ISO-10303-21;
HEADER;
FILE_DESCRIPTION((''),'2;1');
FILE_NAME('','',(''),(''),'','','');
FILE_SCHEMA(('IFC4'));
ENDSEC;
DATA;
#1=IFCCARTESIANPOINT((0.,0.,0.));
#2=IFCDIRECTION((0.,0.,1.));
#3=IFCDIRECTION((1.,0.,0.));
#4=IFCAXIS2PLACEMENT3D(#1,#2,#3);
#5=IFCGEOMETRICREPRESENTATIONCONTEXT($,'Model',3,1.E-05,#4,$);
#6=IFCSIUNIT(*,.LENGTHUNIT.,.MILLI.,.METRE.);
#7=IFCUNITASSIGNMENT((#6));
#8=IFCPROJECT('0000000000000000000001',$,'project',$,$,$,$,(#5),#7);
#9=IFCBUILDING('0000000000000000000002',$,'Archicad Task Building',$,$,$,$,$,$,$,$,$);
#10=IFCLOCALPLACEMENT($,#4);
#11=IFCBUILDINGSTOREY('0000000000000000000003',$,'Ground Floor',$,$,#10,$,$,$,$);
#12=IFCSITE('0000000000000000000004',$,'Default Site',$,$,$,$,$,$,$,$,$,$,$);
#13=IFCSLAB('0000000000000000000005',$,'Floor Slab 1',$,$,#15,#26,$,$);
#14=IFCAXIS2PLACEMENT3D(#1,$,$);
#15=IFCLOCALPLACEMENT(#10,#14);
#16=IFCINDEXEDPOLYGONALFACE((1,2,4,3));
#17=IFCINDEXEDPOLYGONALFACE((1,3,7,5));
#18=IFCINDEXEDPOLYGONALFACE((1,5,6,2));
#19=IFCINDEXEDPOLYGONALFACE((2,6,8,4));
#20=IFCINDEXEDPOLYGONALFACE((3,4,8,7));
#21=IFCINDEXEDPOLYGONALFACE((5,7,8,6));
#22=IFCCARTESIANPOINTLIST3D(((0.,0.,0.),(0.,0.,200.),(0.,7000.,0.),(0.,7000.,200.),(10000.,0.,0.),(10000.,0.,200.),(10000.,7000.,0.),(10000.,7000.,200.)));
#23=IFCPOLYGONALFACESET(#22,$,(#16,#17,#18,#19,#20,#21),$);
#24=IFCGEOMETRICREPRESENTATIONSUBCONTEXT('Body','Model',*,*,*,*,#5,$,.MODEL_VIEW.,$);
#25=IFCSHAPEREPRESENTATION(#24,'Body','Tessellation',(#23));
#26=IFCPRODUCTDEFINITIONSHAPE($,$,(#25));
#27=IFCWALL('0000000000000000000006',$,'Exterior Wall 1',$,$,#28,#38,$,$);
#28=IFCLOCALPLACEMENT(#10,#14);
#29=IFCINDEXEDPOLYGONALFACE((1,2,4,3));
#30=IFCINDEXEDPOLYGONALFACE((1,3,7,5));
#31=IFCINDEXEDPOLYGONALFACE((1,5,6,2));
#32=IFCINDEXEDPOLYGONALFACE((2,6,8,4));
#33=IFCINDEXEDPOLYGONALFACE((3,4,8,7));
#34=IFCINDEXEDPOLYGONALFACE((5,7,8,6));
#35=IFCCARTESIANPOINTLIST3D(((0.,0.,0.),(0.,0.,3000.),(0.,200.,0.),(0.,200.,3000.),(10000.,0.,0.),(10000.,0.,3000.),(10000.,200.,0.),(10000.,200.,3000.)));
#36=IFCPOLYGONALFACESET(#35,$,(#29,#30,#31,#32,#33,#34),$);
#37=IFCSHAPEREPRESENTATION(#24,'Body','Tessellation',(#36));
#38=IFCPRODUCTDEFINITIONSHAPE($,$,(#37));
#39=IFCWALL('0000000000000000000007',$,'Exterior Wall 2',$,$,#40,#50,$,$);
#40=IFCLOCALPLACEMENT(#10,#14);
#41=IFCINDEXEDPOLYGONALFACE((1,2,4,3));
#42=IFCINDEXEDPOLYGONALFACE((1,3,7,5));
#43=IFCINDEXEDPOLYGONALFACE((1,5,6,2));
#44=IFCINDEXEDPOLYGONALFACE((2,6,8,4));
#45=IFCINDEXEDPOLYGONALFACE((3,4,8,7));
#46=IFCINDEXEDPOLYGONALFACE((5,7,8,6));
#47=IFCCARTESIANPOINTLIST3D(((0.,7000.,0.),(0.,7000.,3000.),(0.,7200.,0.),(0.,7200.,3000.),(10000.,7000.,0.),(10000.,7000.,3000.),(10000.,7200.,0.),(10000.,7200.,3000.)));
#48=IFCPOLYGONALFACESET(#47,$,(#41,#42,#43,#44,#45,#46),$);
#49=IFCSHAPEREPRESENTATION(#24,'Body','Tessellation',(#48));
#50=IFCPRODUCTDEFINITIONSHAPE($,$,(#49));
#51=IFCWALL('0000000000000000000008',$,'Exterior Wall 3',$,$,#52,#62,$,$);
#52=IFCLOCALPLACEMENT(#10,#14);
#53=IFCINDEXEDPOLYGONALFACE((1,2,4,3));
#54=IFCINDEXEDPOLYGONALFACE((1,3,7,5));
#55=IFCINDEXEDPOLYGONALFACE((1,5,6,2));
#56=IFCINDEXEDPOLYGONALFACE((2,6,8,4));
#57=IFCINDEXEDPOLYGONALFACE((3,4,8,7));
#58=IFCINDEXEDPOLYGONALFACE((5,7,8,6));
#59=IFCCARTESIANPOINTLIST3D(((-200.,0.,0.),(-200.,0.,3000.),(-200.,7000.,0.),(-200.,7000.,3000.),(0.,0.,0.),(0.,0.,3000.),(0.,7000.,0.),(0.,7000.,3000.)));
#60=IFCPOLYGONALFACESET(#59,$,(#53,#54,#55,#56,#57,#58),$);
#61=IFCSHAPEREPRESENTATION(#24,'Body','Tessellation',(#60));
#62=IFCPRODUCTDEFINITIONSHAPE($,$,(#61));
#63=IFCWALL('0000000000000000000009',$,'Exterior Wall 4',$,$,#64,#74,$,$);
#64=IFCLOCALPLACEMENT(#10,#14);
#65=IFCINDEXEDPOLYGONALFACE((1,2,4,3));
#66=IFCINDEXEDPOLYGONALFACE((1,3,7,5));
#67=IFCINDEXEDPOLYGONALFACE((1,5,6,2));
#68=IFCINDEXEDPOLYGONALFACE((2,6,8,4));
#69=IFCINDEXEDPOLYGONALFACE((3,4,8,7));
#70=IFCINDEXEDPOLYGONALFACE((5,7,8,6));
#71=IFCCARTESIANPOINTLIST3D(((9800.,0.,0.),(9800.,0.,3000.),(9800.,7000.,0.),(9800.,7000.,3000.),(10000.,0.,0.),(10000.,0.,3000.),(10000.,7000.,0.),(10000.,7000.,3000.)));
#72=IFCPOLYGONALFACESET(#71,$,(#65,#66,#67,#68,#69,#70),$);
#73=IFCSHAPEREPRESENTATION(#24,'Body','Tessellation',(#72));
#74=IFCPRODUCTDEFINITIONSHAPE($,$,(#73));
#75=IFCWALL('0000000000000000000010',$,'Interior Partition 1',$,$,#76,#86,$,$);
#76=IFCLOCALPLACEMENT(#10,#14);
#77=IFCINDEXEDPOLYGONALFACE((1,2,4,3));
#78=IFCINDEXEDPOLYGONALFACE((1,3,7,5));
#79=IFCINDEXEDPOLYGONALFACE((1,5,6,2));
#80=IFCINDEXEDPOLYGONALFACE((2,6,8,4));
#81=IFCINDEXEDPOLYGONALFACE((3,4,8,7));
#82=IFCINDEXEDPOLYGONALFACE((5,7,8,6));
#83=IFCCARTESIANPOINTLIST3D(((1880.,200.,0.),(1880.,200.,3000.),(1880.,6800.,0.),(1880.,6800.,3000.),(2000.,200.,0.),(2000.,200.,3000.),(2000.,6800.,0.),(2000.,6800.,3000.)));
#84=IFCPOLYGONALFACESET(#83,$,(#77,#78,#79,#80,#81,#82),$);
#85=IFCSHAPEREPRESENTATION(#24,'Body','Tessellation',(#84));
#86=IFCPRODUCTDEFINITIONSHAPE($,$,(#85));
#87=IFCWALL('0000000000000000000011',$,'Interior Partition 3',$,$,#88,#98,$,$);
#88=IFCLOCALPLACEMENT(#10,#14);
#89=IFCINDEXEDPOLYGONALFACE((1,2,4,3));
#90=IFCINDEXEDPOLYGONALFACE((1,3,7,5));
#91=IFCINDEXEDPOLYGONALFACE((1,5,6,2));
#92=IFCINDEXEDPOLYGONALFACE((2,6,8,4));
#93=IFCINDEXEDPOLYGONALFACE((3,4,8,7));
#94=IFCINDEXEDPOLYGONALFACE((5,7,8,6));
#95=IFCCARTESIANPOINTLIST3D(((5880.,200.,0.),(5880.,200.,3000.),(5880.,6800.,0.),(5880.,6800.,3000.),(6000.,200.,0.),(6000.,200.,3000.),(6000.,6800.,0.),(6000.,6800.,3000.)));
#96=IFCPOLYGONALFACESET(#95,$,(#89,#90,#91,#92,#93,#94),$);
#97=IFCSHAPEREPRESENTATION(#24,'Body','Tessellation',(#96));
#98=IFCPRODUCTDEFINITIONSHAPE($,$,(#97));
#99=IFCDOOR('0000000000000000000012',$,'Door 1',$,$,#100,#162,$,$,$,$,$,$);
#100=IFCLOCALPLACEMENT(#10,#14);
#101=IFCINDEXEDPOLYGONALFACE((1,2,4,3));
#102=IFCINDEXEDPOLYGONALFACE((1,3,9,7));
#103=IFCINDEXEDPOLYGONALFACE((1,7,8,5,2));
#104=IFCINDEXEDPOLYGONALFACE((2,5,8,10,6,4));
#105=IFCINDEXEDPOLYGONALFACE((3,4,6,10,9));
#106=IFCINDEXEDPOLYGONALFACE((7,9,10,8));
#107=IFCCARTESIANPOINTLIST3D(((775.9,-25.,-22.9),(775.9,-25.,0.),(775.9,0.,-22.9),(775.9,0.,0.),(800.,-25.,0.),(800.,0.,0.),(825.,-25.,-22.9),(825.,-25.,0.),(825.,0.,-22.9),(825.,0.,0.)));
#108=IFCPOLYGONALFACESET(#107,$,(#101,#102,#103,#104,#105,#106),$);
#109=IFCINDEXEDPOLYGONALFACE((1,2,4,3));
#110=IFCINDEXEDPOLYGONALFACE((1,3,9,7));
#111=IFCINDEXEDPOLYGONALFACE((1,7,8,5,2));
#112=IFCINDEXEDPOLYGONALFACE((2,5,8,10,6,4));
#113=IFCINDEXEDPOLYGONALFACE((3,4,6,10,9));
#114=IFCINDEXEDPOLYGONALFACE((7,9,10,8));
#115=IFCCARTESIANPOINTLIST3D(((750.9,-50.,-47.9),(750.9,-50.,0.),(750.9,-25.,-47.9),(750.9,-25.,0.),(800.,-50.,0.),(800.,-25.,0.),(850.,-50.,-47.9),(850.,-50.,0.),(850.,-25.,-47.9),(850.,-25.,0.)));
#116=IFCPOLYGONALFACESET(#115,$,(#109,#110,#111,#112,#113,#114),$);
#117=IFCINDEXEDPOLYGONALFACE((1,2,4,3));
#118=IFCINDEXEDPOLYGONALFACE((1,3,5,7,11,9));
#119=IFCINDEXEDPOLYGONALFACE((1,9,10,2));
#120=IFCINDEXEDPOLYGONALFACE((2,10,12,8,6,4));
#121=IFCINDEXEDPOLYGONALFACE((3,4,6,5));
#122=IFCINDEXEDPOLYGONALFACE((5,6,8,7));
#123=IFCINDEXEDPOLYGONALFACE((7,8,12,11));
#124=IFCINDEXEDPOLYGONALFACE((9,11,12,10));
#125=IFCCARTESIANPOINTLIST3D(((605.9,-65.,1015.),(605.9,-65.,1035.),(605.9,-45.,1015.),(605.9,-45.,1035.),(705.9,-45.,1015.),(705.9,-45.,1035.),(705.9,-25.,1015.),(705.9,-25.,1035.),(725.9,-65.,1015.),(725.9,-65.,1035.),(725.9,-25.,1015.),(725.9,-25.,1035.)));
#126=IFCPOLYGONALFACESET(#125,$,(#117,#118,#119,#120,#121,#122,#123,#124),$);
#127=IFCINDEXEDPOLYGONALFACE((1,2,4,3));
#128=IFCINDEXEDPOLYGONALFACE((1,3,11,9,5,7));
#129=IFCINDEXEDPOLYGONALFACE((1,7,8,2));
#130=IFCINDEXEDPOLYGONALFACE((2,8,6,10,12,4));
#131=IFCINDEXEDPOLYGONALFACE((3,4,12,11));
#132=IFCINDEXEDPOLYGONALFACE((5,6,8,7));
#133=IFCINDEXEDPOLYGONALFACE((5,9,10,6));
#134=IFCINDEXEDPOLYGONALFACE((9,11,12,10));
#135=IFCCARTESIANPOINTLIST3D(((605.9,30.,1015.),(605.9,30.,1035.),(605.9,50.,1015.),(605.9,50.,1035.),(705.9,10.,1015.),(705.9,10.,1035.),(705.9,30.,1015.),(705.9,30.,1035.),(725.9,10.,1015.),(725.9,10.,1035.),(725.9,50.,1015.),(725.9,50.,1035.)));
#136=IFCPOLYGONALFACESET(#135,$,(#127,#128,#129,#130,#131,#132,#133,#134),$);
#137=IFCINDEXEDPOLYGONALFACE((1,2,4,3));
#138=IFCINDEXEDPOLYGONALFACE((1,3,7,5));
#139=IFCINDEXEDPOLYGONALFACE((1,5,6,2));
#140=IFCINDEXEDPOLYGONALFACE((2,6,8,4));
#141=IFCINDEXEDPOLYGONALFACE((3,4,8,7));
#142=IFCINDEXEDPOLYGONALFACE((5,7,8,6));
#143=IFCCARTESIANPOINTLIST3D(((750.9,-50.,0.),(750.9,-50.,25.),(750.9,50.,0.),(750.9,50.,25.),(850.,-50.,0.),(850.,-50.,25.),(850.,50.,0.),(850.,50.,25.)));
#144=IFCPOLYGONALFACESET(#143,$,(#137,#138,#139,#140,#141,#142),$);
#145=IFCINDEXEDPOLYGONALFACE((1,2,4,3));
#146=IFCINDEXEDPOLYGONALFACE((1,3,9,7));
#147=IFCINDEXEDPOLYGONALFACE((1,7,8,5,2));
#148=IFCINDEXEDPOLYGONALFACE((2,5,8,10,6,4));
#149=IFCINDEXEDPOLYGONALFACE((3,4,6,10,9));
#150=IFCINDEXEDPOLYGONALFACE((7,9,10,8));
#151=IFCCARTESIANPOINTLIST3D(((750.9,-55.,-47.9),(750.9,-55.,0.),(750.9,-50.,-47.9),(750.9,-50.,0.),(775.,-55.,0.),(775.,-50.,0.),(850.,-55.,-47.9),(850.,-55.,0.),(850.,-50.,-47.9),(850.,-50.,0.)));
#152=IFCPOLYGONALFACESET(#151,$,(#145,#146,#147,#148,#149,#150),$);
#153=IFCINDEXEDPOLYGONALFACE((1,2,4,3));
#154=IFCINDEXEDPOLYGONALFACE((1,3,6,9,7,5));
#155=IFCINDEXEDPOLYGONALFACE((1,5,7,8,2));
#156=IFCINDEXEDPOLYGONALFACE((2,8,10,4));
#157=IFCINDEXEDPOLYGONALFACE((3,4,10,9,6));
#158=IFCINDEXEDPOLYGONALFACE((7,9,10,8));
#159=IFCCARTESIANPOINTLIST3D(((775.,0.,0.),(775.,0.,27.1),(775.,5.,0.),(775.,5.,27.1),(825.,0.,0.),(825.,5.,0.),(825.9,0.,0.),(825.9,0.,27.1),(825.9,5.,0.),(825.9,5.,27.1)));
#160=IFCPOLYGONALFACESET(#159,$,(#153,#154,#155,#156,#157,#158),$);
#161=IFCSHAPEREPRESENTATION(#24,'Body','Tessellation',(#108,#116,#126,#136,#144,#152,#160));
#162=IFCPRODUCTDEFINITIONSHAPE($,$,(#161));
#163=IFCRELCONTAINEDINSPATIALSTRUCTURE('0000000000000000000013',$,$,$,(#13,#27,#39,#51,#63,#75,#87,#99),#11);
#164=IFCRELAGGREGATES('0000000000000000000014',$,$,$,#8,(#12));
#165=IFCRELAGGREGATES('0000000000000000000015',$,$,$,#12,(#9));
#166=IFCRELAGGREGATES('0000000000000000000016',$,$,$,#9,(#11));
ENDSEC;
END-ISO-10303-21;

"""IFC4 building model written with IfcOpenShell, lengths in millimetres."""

from ifc_helpers import new_model, si_unit, frame, origin_with_axes, place, context, subcontext, project, spatial, line, indexed_curve, outline, extrude, element, save


model = new_model("IFC4")

# Units and contexts
model_context = context("Model", 3, precision=1e-05, world=origin_with_axes())
body_context = subcontext(model_context, "Body", "Model", "MODEL_VIEW")
ifc_project = project(units=[si_unit("LENGTHUNIT", "METRE", prefix="MILLI")], contexts=[model_context])

# Site, building, storey
site = spatial("IfcSite", under=ifc_project, Name="Default Site")
building = spatial("IfcBuilding", under=site, Name="Archicad Task Building")
storey_placement = place(None, origin_with_axes())
storey = spatial("IfcBuildingStorey", under=building, at=storey_placement, Name="Ground Floor")

# Slab
slab_placement = place(storey_placement, origin_with_axes())
element("IfcSlab", 1, at=slab_placement, inside=storey, Name="Floor Slab 1", context=body_context, shape_type="SweptSolid", body=[
    extrude(outline(indexed_curve([(0.0, 0.0), (10000.0, 0.0), (10000.0, 7000.0), (0.0, 7000.0), (0.0, 0.0)])), None, (0.0, 0.0, 1.0), 200.0),
])

# Walls
for number, where, z_axis, x_axis, name in (
    (2, (0.0, 0.0, 0.0), (0.0, 0.0, 1.0), (1.0, 0.0, 0.0), "Exterior Wall 1"),
    (3, (0.0, 7000.0, 0.0), (0.0, 0.0, 1.0), (1.0, 0.0, 0.0), "Exterior Wall 2"),
):
    element("IfcWall", number, at=place(storey_placement, frame(where, z_axis=z_axis, x_axis=x_axis)), inside=storey, Name=name, context=body_context, shape_type="SweptSolid", body=[
        extrude(outline(indexed_curve([(0.0, 0.0), (0.0, 200.0), (10000.0, 200.0), (10000.0, 0.0), (0.0, 0.0)], self_intersect=False)), origin_with_axes(), (0.0, 0.0, 1.0), 3000.0),
    ])
for number, where, z_axis, x_axis, name in (
    (4, (0.0, 0.0, 0.0), (0.0, 0.0, 1.0), (0.0, 1.0, 0.0), "Exterior Wall 3"),
    (5, (10000.0, 0.0, 0.0), (0.0, 0.0, 1.0), (0.0, 1.0, 0.0), "Exterior Wall 4"),
):
    element("IfcWall", number, at=place(storey_placement, frame(where, z_axis=z_axis, x_axis=x_axis)), inside=storey, Name=name, context=body_context, shape_type="SweptSolid", body=[
        extrude(outline(indexed_curve([(0.0, 0.0), (0.0, 200.0), (7000.0, 200.0), (7000.0, 0.0), (0.0, 0.0)], self_intersect=False)), origin_with_axes(), (0.0, 0.0, 1.0), 3000.0),
    ])
for number, where, z_axis, x_axis, name in (
    (6, (2000.0, 200.0, 0.0), (0.0, 0.0, 1.0), (0.0, 1.0, 0.0), "Interior Partition 1"),
    (7, (6000.0, 200.0, 0.0), (0.0, 0.0, 1.0), (0.0, 1.0, 0.0), "Interior Partition 3"),
):
    element("IfcWall", number, at=place(storey_placement, frame(where, z_axis=z_axis, x_axis=x_axis)), inside=storey, Name=name, context=body_context, shape_type="SweptSolid", body=[
        extrude(outline(indexed_curve([(0.0, 0.0), (0.0, 120.0), (6600.0, 120.0), (6600.0, 0.0), (0.0, 0.0)], self_intersect=False)), origin_with_axes(), (0.0, 0.0, 1.0), 3000.0),
    ])

# Door
door_1_placement = place(storey_placement, frame((800.0, -50.0, 0.0), z_axis=(0.0, 0.0, 1.0), x_axis=(1.0, 0.0, 0.0)))
element("IfcDoor", 8, at=door_1_placement, inside=storey, Name="Door 1", context=body_context, shape_type="SweptSolid", body=[
    extrude(outline(indexed_curve([(0.0, 0.0), (0.0, 2.1), (0.9, 2.1), (0.9, 0.0), (-24.1, 0.0), (-24.1, -22.9), (25.0, -22.9), (25.0, 0.0)], segments=[line(1, 2, 3, 4, 5, 6, 7, 8, 1)])), frame((0.0, 25.0, 0.0), z_axis=(0.0, -1.0, 0.0), x_axis=(1.0, 0.0, 0.0)), (0.0, 0.0, -1.0), 25.0),
    extrude(outline(indexed_curve([(0.0, 0.0), (0.0, 2.1), (0.9, 2.1), (0.9, 0.0), (-49.1, 0.0), (-49.1, -47.9), (50.0, -47.9), (50.0, 0.0)], segments=[line(1, 2, 3, 4, 5, 6, 7, 8, 1)])), frame((0.0, 0.0, 0.0), z_axis=(0.0, -1.0, 0.0), x_axis=(1.0, 0.0, 0.0)), (0.0, 0.0, -1.0), 25.0),
    extrude(outline(indexed_curve([(0.0, 0.0), (-49.1, 0.0), (-49.1, 35.0), (0.0, 35.0)], segments=[line(1, 2, 3, 4, 1)])), frame((25.0, 25.0, 25.0), z_axis=(0.0, 0.0, 1.0), x_axis=(1.0, 0.0, 0.0)), (0.0, 0.0, 1.0), -47.9),
    extrude(outline(indexed_curve([(0.0, 0.0), (0.0, -40.0), (-120.0, -40.0), (-120.0, -20.0), (-20.0, -20.0), (-20.0, 0.0)], segments=[line(1, 2, 3, 4, 5, 6, 1)])), frame((-74.1, 25.0, 1015.0), z_axis=(0.0, 0.0, 1.0), x_axis=(1.0, 0.0, 0.0)), (0.0, 0.0, 1.0), 20.0),
    extrude(outline(indexed_curve([(0.0, 0.0), (0.0, 40.0), (-120.0, 40.0), (-120.0, 20.0), (-20.0, 20.0), (-20.0, 0.0)], segments=[line(1, 2, 3, 4, 5, 6, 1)])), frame((-74.1, 60.0, 1015.0), z_axis=(0.0, 0.0, 1.0), x_axis=(1.0, 0.0, 0.0)), (0.0, 0.0, 1.0), 20.0),
    extrude(outline(indexed_curve([(0.0, 0.0), (-99.1, 0.0), (-99.1, 100.0), (0.0, 100.0)], segments=[line(1, 2, 3, 4, 1)])), frame((50.0, 0.0, 0.0), z_axis=(0.0, 0.0, 1.0), x_axis=(1.0, 0.0, 0.0)), (0.0, 0.0, 1.0), 25.0),
    extrude(outline(indexed_curve([(0.0, 0.0), (0.0, 27.1), (50.9, 27.1), (50.9, 0.0), (-24.1, 0.0), (-24.1, -47.9), (75.0, -47.9), (75.0, 0.0)], segments=[line(1, 2, 3, 4, 5, 6, 7, 8, 1)])), frame((-25.0, -5.0, 0.0), z_axis=(0.0, -1.0, 0.0), x_axis=(1.0, 0.0, 0.0)), (0.0, 0.0, -1.0), 5.0),
    extrude(outline(indexed_curve([(0.0, 0.0), (0.0, 27.1), (50.9, 27.1), (50.9, 0.0), (0.9, 0.0), (0.9, -22.9), (50.0, -22.9), (50.0, 0.0)], segments=[line(1, 2, 3, 4, 5, 6, 7, 8, 1)])), frame((-25.0, 50.0, 0.0), z_axis=(0.0, -1.0, 0.0), x_axis=(1.0, 0.0, 0.0)), (0.0, 0.0, -1.0), 5.0),
])

save(model, "model.ifc")
